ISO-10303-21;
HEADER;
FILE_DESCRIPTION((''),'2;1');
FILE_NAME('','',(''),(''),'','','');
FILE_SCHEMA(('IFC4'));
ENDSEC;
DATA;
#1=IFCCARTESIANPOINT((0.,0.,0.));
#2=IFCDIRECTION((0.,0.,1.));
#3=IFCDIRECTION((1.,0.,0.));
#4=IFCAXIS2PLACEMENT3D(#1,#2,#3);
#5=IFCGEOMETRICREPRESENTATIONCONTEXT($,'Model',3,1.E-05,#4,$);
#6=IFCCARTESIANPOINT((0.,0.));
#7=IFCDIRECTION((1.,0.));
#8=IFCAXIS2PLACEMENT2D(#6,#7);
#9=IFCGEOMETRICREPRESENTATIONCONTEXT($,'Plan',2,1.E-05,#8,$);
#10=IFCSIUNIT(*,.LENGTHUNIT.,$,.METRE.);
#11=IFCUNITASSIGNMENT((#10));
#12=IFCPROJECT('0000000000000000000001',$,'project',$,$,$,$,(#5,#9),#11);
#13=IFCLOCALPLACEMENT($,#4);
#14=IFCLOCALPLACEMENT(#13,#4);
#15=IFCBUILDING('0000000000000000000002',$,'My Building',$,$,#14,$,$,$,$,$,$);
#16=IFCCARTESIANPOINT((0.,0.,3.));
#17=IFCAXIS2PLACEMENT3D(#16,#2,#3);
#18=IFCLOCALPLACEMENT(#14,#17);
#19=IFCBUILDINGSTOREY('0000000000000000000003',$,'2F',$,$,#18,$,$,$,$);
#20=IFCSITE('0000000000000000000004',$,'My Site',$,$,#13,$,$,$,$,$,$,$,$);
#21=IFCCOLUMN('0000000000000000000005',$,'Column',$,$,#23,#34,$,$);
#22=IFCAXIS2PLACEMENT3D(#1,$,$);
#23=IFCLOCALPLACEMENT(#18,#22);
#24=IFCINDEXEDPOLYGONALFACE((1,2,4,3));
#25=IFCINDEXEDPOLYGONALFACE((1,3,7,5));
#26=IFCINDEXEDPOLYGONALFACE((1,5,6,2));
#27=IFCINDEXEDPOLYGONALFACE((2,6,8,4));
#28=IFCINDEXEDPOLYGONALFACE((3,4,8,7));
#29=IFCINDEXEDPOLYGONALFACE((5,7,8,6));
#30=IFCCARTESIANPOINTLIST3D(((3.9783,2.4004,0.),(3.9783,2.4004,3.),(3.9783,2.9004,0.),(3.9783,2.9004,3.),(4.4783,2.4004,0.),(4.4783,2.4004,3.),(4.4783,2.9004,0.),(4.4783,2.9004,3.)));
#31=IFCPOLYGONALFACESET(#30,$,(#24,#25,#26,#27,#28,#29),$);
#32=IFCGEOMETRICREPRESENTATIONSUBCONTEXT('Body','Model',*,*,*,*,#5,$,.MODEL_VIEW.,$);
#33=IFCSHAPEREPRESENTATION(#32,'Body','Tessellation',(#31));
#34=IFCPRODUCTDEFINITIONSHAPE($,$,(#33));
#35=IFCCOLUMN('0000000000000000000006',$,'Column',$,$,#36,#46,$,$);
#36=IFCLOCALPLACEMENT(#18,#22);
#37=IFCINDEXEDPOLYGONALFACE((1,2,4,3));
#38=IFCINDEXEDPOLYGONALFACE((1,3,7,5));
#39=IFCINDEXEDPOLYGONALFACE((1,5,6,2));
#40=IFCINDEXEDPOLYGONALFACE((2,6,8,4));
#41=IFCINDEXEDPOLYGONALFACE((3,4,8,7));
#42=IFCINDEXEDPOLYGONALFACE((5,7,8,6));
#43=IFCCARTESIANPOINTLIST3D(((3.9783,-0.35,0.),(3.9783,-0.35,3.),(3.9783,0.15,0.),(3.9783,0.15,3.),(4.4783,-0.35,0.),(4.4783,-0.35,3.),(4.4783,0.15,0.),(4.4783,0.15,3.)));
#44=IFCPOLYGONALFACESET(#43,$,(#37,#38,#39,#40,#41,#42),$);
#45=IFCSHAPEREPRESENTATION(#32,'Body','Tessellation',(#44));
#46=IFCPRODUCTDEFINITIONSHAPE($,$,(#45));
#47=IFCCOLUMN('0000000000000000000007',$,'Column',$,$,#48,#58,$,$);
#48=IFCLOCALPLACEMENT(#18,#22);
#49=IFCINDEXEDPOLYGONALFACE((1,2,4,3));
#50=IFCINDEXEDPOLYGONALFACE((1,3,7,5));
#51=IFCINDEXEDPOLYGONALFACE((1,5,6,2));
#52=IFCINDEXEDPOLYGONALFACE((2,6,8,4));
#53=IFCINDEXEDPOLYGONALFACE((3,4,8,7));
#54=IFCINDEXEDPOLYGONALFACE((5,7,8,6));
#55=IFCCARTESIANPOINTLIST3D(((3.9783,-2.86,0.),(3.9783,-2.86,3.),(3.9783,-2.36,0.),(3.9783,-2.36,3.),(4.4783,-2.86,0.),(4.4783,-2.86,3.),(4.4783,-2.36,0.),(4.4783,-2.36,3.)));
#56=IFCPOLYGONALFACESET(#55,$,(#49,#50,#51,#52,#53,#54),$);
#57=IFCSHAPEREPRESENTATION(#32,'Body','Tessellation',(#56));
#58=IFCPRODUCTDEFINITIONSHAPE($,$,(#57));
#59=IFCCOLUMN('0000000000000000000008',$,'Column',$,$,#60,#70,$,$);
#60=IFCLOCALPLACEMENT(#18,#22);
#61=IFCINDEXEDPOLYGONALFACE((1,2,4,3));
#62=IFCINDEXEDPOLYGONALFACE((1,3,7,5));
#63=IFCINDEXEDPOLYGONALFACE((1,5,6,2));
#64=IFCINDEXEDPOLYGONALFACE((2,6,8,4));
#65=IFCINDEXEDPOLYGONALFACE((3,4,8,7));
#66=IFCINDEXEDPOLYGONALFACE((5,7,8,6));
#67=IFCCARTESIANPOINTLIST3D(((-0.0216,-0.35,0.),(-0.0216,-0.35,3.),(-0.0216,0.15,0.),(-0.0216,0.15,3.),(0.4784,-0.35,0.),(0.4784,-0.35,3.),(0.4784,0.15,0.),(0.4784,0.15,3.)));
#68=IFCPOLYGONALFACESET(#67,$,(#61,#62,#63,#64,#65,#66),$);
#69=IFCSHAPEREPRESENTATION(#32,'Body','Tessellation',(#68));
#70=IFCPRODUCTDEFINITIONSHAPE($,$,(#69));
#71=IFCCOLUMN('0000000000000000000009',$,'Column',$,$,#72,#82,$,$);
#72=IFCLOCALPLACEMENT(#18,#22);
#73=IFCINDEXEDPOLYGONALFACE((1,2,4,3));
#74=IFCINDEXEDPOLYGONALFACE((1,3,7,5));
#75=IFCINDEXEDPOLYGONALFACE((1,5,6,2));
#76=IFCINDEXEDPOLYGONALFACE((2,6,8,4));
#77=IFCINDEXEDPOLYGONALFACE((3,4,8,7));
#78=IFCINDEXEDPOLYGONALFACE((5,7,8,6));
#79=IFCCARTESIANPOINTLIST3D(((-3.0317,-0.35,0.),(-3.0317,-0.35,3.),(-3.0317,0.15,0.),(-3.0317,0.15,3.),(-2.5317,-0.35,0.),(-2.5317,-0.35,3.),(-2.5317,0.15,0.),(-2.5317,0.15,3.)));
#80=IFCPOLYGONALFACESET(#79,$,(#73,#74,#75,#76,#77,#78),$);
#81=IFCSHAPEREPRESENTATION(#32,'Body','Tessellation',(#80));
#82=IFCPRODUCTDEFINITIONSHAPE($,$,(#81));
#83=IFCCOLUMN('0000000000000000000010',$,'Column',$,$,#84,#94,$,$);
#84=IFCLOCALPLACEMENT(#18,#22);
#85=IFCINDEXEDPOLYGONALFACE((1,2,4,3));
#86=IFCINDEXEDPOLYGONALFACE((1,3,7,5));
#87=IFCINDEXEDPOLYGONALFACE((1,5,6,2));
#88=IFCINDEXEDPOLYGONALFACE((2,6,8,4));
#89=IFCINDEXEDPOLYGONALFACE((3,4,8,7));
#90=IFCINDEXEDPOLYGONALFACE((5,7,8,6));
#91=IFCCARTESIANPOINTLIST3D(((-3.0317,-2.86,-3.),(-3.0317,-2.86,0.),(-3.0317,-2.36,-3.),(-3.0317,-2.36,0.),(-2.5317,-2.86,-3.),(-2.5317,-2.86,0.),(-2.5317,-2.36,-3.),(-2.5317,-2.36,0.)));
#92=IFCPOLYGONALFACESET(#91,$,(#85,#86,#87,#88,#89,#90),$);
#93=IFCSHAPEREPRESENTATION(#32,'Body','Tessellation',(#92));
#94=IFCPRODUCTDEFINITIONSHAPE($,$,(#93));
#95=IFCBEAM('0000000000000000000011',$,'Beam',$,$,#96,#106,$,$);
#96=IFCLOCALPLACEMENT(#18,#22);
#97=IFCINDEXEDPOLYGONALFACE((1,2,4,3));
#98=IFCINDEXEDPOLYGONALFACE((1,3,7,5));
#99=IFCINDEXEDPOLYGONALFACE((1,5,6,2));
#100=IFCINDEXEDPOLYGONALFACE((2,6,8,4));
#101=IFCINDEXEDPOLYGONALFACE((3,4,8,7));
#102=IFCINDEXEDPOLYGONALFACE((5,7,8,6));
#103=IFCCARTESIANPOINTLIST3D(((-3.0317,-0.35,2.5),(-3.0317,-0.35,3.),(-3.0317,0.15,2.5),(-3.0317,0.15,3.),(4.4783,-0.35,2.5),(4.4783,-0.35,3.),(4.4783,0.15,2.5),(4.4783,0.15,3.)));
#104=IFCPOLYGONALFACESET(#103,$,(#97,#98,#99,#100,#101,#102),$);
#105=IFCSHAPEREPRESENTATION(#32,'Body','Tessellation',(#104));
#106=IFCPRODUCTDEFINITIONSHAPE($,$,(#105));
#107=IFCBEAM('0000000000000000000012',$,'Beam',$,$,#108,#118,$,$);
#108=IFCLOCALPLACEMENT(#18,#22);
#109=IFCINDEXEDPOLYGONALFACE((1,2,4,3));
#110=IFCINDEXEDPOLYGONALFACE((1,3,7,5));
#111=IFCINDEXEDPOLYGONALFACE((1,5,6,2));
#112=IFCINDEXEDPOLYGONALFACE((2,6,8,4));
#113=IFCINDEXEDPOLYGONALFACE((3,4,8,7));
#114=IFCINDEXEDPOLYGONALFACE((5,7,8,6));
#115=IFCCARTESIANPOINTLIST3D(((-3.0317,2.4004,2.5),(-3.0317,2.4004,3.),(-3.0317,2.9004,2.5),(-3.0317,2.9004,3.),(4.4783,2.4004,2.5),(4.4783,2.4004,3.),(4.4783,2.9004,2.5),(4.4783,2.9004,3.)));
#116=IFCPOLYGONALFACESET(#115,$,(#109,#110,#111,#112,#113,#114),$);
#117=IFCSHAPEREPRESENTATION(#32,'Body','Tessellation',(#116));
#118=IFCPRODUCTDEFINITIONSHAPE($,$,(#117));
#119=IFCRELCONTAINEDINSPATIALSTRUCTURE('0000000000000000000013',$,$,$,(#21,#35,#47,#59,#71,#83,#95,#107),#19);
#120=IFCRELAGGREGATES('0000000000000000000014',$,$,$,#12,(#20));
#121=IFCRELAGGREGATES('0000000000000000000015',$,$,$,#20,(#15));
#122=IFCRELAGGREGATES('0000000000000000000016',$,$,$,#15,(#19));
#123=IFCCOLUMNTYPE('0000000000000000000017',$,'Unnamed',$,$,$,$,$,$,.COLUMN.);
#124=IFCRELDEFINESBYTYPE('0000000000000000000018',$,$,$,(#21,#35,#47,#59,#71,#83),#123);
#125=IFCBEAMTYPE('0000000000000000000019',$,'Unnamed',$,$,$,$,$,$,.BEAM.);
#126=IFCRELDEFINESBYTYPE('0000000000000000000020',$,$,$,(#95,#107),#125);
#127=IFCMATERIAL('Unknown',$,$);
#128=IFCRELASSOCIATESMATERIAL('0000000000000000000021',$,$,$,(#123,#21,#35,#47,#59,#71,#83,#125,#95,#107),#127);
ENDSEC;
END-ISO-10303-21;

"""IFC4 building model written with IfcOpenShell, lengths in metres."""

from ifc_helpers import new_model, si_unit, frame, origin_with_axes, origin_2d_with_axis, place, context, subcontext, project, spatial, rectangle, extrude, material, material_profile, profile_set, profile_usage, type_object, element, save


model = new_model("IFC4")

# Units and contexts
model_context = context("Model", 3, precision=1e-05, world=origin_with_axes())
plan_context = context("Plan", 2, precision=1e-05, world=origin_2d_with_axis())
body_context_1 = subcontext(model_context, "Body", "Model", "MODEL_VIEW")
ifc_project = project(units=[si_unit("LENGTHUNIT", "METRE")], contexts=[model_context, plan_context])

# Site, building, storey
site_placement = place(None, origin_with_axes())
site = spatial("IfcSite", under=ifc_project, at=site_placement, Name="My Site")
building_placement = place(site_placement, origin_with_axes())
building = spatial("IfcBuilding", under=site, at=building_placement, Name="My Building")
storey_placement = place(building_placement, frame((0.0, 0.0, 3.0), z_axis=(0.0, 0.0, 1.0), x_axis=(1.0, 0.0, 0.0)))
storey = spatial("IfcBuildingStorey", under=building, at=storey_placement, Name="2F")

# Columns
ifc_material = material(Name="Unknown")
ifc_material_profile_1 = material_profile(ifc_material, rectangle(XDim=0.5, YDim=0.5))
ifc_profile_set_1 = profile_set([ifc_material_profile_1])
ifc_profile_usage_1 = profile_usage(ifc_profile_set_1, cardinal=7)
column_type = type_object("IfcColumnType", Name="Unnamed", PredefinedType="COLUMN", material=ifc_profile_set_1)
column_1_placement = place(storey_placement, frame((4.4783, 2.9004, 0.0), z_axis=(0.0, 0.0, 1.0), x_axis=(1.0, 0.0, 0.0)))
element("IfcColumn", 1, at=column_1_placement, inside=storey, type_object=column_type, material=ifc_profile_usage_1, Name="Column", context=body_context_1, shape_type="SweptSolid", body=[
    extrude(rectangle(XDim=0.5, YDim=0.5), frame((-0.25, -0.25, 0.0), z_axis=(0.0, 0.0, 1.0), x_axis=(1.0, 0.0, 0.0)), (0.0, 0.0, 1.0), 3.0),
])
ifc_profile_usage_2 = profile_usage(ifc_profile_set_1, cardinal=7)
column_2_placement = place(storey_placement, frame((4.4783, 0.15, 0.0), z_axis=(0.0, 0.0, 1.0), x_axis=(1.0, 0.0, 0.0)))
element("IfcColumn", 2, at=column_2_placement, inside=storey, type_object=column_type, material=ifc_profile_usage_2, Name="Column", context=body_context_1, shape_type="SweptSolid", body=[
    extrude(rectangle(XDim=0.5, YDim=0.5), frame((-0.25, -0.25, 0.0), z_axis=(0.0, 0.0, 1.0), x_axis=(1.0, 0.0, 0.0)), (0.0, 0.0, 1.0), 3.0),
])
ifc_profile_usage_3 = profile_usage(ifc_profile_set_1, cardinal=7)
column_3_placement = place(storey_placement, frame((4.4783, -2.36, 0.0), z_axis=(0.0, 0.0, 1.0), x_axis=(1.0, 0.0, 0.0)))
element("IfcColumn", 3, at=column_3_placement, inside=storey, type_object=column_type, material=ifc_profile_usage_3, Name="Column", context=body_context_1, shape_type="SweptSolid", body=[
    extrude(rectangle(XDim=0.5, YDim=0.5), frame((-0.25, -0.25, 0.0), z_axis=(0.0, 0.0, 1.0), x_axis=(1.0, 0.0, 0.0)), (0.0, 0.0, 1.0), 3.0),
])
ifc_profile_usage_4 = profile_usage(ifc_profile_set_1, cardinal=7)
column_4_placement = place(storey_placement, frame((0.4784, 0.15, 0.0), z_axis=(0.0, 0.0, 1.0), x_axis=(1.0, 0.0, 0.0)))
element("IfcColumn", 4, at=column_4_placement, inside=storey, type_object=column_type, material=ifc_profile_usage_4, Name="Column", context=body_context_1, shape_type="SweptSolid", body=[
    extrude(rectangle(XDim=0.5, YDim=0.5), frame((-0.25, -0.25, 0.0), z_axis=(0.0, 0.0, 1.0), x_axis=(1.0, 0.0, 0.0)), (0.0, 0.0, 1.0), 3.0),
])
ifc_profile_usage_5 = profile_usage(ifc_profile_set_1, cardinal=7)
column_5_placement = place(storey_placement, frame((-2.5317, 0.15, 0.0), z_axis=(0.0, 0.0, 1.0), x_axis=(1.0, 0.0, 0.0)))
element("IfcColumn", 5, at=column_5_placement, inside=storey, type_object=column_type, material=ifc_profile_usage_5, Name="Column", context=body_context_1, shape_type="SweptSolid", body=[
    extrude(rectangle(XDim=0.5, YDim=0.5), frame((-0.25, -0.25, 0.0), z_axis=(0.0, 0.0, 1.0), x_axis=(1.0, 0.0, 0.0)), (0.0, 0.0, 1.0), 3.0),
])
ifc_profile_usage_6 = profile_usage(ifc_profile_set_1, cardinal=7)
column_6_placement = place(storey_placement, frame((-2.5317, -2.36, -3.0), z_axis=(0.0, 0.0, 1.0), x_axis=(1.0, 0.0, 0.0)))
element("IfcColumn", 6, at=column_6_placement, inside=storey, type_object=column_type, material=ifc_profile_usage_6, Name="Column", context=body_context_1, shape_type="SweptSolid", body=[
    extrude(rectangle(XDim=0.5, YDim=0.5), frame((-0.25, -0.25, 0.0), z_axis=(0.0, 0.0, 1.0), x_axis=(1.0, 0.0, 0.0)), (0.0, 0.0, 1.0), 3.0),
])

# Beams
ifc_material_profile_2 = material_profile(ifc_material, rectangle(XDim=0.5, YDim=0.5))
ifc_profile_set_2 = profile_set([ifc_material_profile_2])
ifc_profile_usage_7 = profile_usage(ifc_profile_set_2, cardinal=7)
beam_type = type_object("IfcBeamType", Name="Unnamed", PredefinedType="BEAM", material=ifc_profile_set_2)
beam_1_placement = place(storey_placement, frame((4.4783, -0.35, 3.0), z_axis=(-1.0, 0.0, 0.0), x_axis=(0.0, -1.0, 0.0)))
element("IfcBeam", 7, at=beam_1_placement, inside=storey, type_object=beam_type, material=ifc_profile_usage_7, Name="Beam", context=body_context_1, shape_type="SweptSolid", body=[
    extrude(rectangle(XDim=0.5, YDim=0.5), frame((-0.25, -0.25, 0.0), z_axis=(0.0, 0.0, 1.0), x_axis=(1.0, 0.0, 0.0)), (0.0, 0.0, 1.0), 7.51),
])
ifc_profile_usage_8 = profile_usage(ifc_profile_set_2, cardinal=7)
beam_2_placement = place(storey_placement, frame((4.4783, 2.4004, 3.0), z_axis=(-1.0, 0.0, 0.0), x_axis=(0.0, -1.0, 0.0)))
element("IfcBeam", 8, at=beam_2_placement, inside=storey, type_object=beam_type, material=ifc_profile_usage_8, Name="Beam", context=body_context_1, shape_type="SweptSolid", body=[
    extrude(rectangle(XDim=0.5, YDim=0.5), frame((-0.25, -0.25, 0.0), z_axis=(0.0, 0.0, 1.0), x_axis=(1.0, 0.0, 0.0)), (0.0, 0.0, 1.0), 7.51),
])

save(model, "model.ifc")
